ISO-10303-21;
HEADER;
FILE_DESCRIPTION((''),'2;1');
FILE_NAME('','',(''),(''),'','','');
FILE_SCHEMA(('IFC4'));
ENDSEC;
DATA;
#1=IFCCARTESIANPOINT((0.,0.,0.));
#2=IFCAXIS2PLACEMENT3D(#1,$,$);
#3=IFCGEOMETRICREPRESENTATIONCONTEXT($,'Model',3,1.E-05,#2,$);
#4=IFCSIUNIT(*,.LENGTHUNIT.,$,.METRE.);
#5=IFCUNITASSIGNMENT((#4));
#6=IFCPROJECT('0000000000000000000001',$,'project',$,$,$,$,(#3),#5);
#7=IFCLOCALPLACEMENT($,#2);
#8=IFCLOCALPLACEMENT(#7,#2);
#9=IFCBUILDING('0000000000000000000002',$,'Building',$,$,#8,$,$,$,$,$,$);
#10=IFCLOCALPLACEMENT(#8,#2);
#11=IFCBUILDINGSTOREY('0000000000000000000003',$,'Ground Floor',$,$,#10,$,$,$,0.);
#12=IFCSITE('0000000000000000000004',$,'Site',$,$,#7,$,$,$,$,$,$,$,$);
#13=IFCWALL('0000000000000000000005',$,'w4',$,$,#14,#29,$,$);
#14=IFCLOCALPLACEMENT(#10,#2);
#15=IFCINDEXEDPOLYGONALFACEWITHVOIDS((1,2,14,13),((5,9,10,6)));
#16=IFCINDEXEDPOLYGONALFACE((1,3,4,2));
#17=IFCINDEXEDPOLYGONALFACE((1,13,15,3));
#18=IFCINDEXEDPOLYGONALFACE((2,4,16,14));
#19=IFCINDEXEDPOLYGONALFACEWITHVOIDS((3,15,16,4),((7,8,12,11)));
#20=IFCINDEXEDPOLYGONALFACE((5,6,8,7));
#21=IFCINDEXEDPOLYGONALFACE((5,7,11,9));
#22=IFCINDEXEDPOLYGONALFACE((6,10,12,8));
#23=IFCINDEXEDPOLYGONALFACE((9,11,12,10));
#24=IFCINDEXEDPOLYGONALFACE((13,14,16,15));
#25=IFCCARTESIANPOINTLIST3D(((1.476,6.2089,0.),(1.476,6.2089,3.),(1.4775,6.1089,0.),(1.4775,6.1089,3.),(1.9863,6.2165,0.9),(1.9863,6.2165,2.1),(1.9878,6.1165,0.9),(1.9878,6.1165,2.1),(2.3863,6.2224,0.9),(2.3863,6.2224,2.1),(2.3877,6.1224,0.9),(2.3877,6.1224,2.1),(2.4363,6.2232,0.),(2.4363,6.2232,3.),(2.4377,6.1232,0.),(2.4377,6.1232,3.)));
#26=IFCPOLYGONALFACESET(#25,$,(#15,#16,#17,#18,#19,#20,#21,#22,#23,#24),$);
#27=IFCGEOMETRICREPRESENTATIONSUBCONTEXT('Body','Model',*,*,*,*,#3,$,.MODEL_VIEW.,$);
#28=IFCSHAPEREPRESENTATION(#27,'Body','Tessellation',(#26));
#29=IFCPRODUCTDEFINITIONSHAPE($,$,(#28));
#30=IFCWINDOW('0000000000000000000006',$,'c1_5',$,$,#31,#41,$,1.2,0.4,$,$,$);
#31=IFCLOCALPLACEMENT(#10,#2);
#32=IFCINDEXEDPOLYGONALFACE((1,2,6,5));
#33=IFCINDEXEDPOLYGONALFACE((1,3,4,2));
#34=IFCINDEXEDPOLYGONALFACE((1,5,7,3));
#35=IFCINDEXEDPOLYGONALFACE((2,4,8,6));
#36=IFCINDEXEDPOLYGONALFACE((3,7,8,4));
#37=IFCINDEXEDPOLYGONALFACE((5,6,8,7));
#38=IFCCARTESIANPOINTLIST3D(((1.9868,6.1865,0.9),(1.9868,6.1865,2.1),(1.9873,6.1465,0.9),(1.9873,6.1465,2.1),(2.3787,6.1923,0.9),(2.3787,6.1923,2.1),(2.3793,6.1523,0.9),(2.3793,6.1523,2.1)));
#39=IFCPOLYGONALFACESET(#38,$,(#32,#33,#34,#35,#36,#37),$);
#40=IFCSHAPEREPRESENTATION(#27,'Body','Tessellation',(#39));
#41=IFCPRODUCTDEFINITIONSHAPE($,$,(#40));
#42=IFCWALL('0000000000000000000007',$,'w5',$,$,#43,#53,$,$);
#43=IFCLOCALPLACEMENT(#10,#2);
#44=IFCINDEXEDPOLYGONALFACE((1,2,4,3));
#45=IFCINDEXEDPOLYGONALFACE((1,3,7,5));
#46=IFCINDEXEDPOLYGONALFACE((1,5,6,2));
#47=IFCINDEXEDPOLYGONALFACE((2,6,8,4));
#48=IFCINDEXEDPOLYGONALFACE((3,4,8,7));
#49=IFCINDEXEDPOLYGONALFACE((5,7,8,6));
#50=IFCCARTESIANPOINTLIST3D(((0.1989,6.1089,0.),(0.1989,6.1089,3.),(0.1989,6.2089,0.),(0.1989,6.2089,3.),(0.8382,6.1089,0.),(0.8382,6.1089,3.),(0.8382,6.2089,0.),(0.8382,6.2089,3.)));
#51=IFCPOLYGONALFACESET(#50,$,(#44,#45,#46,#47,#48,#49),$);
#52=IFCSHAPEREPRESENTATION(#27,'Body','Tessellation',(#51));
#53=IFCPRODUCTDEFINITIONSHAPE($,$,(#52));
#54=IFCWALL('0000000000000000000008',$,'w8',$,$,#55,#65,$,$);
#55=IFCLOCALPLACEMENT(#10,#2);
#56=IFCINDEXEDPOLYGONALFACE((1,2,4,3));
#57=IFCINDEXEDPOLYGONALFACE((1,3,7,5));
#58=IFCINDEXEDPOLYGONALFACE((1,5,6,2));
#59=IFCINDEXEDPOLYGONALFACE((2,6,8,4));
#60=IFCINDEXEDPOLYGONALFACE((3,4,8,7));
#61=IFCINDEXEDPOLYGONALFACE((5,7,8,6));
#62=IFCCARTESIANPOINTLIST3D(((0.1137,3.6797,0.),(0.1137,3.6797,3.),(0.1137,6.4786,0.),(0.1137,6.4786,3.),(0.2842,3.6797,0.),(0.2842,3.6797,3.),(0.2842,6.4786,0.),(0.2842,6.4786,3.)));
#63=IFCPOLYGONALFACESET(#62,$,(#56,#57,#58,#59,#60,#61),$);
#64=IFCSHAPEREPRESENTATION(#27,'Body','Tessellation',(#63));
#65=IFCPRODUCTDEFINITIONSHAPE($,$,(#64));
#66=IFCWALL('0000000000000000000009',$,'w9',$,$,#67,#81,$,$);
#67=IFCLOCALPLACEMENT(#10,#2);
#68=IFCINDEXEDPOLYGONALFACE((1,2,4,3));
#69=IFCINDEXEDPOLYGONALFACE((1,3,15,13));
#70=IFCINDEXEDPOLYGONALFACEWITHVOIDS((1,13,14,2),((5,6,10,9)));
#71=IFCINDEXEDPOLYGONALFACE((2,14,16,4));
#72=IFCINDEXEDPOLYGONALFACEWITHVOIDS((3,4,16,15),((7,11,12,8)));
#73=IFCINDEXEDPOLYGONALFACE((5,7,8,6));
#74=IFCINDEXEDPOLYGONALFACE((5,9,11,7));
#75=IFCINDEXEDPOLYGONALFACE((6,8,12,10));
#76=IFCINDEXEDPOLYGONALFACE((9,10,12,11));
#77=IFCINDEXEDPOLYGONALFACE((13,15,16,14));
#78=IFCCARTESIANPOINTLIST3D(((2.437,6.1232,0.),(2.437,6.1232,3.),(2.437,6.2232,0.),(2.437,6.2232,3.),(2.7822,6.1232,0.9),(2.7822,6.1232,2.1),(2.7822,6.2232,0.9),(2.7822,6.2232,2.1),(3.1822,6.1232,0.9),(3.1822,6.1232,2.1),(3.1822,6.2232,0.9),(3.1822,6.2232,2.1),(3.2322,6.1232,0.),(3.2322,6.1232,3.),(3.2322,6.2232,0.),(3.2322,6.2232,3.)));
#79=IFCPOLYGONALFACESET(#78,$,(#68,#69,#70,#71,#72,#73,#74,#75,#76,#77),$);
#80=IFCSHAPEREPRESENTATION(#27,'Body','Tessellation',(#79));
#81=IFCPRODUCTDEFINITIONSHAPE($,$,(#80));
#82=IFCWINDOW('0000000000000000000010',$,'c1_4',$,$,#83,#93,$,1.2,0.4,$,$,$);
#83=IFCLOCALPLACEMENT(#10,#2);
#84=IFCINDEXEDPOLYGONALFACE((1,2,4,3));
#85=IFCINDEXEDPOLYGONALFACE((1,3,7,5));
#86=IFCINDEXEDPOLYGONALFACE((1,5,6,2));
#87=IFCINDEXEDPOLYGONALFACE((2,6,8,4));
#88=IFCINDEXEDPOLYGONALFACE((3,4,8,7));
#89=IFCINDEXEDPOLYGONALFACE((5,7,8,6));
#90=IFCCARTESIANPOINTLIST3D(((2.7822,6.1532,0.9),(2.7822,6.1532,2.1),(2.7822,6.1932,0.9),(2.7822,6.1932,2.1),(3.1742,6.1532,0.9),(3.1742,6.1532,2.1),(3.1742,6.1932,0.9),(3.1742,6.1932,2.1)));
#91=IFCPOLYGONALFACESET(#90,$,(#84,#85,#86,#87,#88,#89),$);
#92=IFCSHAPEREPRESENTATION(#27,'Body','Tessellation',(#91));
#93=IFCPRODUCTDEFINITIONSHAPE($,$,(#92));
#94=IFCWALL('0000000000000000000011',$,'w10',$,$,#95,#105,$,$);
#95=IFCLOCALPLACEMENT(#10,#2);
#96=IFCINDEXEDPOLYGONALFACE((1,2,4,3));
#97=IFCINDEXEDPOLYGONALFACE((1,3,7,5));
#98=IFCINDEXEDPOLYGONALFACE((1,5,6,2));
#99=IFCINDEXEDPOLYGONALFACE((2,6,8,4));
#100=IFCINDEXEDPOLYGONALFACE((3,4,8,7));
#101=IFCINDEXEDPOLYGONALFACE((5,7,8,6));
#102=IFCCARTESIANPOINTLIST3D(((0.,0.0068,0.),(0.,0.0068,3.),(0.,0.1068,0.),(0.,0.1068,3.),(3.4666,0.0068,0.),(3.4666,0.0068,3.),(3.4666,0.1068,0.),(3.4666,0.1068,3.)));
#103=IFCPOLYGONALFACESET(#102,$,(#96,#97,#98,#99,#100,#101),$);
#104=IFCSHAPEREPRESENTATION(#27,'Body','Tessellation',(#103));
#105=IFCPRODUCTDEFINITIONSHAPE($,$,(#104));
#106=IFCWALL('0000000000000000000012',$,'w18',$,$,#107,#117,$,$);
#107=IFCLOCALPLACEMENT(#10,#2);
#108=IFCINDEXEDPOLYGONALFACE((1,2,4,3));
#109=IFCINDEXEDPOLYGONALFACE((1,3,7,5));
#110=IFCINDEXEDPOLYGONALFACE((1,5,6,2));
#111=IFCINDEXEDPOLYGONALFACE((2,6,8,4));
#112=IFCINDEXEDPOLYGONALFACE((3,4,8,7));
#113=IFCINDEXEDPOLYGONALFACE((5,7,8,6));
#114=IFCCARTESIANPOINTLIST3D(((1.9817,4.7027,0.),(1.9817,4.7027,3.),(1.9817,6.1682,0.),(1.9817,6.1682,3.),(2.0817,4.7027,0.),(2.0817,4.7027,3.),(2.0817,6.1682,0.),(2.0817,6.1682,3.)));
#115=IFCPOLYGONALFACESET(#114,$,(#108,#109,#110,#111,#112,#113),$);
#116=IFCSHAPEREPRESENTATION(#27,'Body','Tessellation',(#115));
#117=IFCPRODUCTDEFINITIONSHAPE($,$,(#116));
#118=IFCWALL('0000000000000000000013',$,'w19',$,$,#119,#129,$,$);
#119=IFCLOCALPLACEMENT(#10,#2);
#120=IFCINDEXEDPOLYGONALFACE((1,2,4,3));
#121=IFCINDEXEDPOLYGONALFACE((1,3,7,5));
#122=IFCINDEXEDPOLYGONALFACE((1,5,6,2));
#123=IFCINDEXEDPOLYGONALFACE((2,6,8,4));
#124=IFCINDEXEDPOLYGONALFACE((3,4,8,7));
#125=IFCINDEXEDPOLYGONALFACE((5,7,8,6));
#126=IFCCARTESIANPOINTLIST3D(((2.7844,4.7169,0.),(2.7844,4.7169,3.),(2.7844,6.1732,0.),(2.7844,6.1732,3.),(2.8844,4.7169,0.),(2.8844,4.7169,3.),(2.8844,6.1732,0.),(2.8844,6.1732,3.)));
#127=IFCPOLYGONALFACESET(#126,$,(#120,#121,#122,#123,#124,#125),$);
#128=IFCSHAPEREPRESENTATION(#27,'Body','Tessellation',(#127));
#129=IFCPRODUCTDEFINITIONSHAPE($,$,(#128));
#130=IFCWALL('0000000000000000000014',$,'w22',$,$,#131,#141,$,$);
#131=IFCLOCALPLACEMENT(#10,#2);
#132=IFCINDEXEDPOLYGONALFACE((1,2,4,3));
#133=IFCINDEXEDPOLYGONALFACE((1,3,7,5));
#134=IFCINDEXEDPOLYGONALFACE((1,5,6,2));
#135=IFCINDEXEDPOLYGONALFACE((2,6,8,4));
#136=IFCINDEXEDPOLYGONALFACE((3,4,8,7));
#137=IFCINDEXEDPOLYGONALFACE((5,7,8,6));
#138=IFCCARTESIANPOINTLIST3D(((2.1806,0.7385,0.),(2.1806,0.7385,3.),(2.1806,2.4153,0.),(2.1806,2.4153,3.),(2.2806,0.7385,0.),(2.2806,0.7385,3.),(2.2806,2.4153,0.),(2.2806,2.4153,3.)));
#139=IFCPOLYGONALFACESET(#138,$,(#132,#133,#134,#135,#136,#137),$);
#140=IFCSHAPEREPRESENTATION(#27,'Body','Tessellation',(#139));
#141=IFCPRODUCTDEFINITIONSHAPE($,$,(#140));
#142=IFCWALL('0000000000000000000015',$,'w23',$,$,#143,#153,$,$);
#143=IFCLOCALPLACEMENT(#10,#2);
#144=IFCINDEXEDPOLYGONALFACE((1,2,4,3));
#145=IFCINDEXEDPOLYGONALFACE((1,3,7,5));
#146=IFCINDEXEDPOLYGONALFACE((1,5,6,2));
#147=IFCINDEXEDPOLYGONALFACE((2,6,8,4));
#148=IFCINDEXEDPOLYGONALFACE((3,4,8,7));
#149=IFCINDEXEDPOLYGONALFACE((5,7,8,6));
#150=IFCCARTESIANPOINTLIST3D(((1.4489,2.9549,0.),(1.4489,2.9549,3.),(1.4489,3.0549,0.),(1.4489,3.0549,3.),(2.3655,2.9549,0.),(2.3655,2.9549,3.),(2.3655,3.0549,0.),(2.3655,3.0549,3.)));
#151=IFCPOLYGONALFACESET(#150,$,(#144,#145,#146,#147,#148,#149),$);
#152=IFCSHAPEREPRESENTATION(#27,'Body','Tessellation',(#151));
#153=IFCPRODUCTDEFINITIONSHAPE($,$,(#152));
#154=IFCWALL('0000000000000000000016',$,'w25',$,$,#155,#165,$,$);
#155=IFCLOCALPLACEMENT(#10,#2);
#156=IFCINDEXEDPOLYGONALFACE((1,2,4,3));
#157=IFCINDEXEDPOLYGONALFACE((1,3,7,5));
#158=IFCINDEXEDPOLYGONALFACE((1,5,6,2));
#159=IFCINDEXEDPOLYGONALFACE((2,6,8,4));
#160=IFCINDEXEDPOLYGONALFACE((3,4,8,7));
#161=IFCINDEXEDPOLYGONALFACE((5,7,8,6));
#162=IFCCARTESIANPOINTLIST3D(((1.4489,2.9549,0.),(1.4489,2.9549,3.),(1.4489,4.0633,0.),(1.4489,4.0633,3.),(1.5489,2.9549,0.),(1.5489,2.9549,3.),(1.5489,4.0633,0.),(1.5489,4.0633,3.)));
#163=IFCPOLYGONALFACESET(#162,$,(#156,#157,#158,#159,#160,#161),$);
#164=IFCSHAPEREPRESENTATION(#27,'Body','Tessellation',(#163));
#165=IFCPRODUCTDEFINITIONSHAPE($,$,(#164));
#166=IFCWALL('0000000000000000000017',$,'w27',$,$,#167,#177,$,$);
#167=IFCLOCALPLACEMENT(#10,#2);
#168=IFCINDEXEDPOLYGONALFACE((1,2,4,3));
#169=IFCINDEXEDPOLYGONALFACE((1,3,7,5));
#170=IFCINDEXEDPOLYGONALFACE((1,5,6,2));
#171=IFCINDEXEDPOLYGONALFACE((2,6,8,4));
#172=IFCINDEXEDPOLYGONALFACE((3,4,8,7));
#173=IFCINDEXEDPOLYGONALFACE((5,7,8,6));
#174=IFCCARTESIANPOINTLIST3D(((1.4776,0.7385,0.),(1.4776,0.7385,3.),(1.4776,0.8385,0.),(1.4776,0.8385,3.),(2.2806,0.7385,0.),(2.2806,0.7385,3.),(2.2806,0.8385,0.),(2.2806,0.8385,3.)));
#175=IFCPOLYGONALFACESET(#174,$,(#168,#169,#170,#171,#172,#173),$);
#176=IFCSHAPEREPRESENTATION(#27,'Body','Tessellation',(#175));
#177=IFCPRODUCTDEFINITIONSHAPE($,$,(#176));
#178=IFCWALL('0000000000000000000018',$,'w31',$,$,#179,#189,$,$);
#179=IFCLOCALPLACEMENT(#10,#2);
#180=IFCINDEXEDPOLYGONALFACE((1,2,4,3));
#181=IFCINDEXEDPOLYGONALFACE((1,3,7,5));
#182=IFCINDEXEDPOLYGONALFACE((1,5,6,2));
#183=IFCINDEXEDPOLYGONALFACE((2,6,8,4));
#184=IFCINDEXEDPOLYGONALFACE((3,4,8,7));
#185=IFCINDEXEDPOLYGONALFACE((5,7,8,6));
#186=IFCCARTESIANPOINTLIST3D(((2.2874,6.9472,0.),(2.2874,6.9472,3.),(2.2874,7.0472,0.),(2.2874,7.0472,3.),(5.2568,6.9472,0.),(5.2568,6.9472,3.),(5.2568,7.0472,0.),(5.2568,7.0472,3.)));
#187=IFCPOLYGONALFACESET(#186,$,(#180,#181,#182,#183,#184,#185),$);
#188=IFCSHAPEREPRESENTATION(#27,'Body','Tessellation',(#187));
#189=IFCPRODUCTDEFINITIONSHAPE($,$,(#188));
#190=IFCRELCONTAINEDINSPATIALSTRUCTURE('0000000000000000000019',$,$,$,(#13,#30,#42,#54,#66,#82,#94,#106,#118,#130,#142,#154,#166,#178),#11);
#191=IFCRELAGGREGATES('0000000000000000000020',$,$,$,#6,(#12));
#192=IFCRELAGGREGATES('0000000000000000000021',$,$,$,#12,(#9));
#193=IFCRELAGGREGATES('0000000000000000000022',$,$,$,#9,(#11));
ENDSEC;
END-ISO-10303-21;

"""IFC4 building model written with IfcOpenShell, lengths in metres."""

from ifc_helpers import new_model, si_unit, frame, origin, place, context, subcontext, project, spatial, polyline, outline, extrude, element, fill, save


model = new_model("IFC4")

# Units and contexts
model_context = context("Model", 3, precision=1e-05, world=origin())
body_context = subcontext(model_context, "Body", "Model", "MODEL_VIEW")
ifc_project = project(units=[si_unit("LENGTHUNIT", "METRE")], contexts=[model_context])

# Site, building, storey
site_placement = place(None, origin())
site = spatial("IfcSite", under=ifc_project, at=site_placement, Name="Site")
building_placement = place(site_placement, origin())
building = spatial("IfcBuilding", under=site, at=building_placement, Name="Building")
storey_placement = place(building_placement, origin())
storey = spatial("IfcBuildingStorey", under=building, at=storey_placement, Name="Ground Floor", Elevation=0.0)

# Wall, opening, window
wall_1_placement = place(storey_placement, frame((1.4768, 6.1589, 0.0), x_axis=(0.99989, 0.014814, 0.0)))
wall_1 = element("IfcWall", 1, at=wall_1_placement, inside=storey, Name="w4", context=body_context, shape_type="SweptSolid", body=[
    extrude(outline(polyline([(0.0, -0.05), (0.9604, -0.05), (0.9604, 0.05), (0.0, 0.05), (0.0, -0.05)])), origin(), (0.0, 0.0, 1.0), 3.0),
])
opening_1_placement = place(wall_1_placement, frame((0.5104, 0.0, 0.0)))
opening_1 = element("IfcOpeningElement", 2, at=opening_1_placement, cuts=wall_1, context=body_context, shape_type="SweptSolid", body=[
    extrude(outline(polyline([(0.0, -0.0525), (0.4, -0.0525), (0.4, 0.0525), (0.0, 0.0525), (0.0, -0.0525)])), frame((0.0, 0.0, 0.9)), (0.0, 0.0, 1.0), 1.2),
])
window_1_placement = place(wall_1_placement, frame((0.5104, 0.0, 0.0)))
window_1 = element("IfcWindow", 3, at=window_1_placement, inside=storey, Name="c1_5", OverallHeight=1.2, OverallWidth=0.4, context=body_context, shape_type="SweptSolid", body=[
    extrude(outline(polyline([(0.0, -0.02), (0.392, -0.02), (0.392, 0.02), (0.0, 0.02), (0.0, -0.02)])), frame((0.0, 0.0, 0.9)), (0.0, 0.0, 1.0), 1.2),
])
fill(opening_1, window_1)

# Walls
wall_2_placement = place(storey_placement, frame((0.1989, 6.1589, 0.0), x_axis=(1.0, 0.0, 0.0)))
element("IfcWall", 4, at=wall_2_placement, inside=storey, Name="w5", context=body_context, shape_type="SweptSolid", body=[
    extrude(outline(polyline([(0.0, -0.05), (0.6393, -0.05), (0.6393, 0.05), (0.0, 0.05), (0.0, -0.05)])), origin(), (0.0, 0.0, 1.0), 3.0),
])
wall_3_placement = place(storey_placement, frame((0.1989, 3.6797, 0.0), x_axis=(0.0, 1.0, 0.0)))
element("IfcWall", 5, at=wall_3_placement, inside=storey, Name="w8", context=body_context, shape_type="SweptSolid", body=[
    extrude(outline(polyline([(0.0, -0.0852), (2.7989, -0.0852), (2.7989, 0.0852), (0.0, 0.0852), (0.0, -0.0852)])), origin(), (0.0, 0.0, 1.0), 3.0),
])

# Wall, opening, window
wall_4_placement = place(storey_placement, frame((2.437, 6.1732, 0.0), x_axis=(1.0, -0.000009, 0.0)))
wall_4 = element("IfcWall", 6, at=wall_4_placement, inside=storey, Name="w9", context=body_context, shape_type="SweptSolid", body=[
    extrude(outline(polyline([(0.0, -0.05), (0.7952, -0.05), (0.7952, 0.05), (0.0, 0.05), (0.0, -0.05)])), origin(), (0.0, 0.0, 1.0), 3.0),
])
opening_2_placement = place(wall_4_placement, frame((0.3452, 0.0, 0.0)))
opening_2 = element("IfcOpeningElement", 7, at=opening_2_placement, cuts=wall_4, context=body_context, shape_type="SweptSolid", body=[
    extrude(outline(polyline([(0.0, -0.0525), (0.4, -0.0525), (0.4, 0.0525), (0.0, 0.0525), (0.0, -0.0525)])), frame((0.0, 0.0, 0.9)), (0.0, 0.0, 1.0), 1.2),
])
window_2_placement = place(wall_4_placement, frame((0.3452, 0.0, 0.0)))
window_2 = element("IfcWindow", 8, at=window_2_placement, inside=storey, Name="c1_4", OverallHeight=1.2, OverallWidth=0.4, context=body_context, shape_type="SweptSolid", body=[
    extrude(outline(polyline([(0.0, -0.02), (0.392, -0.02), (0.392, 0.02), (0.0, 0.02), (0.0, -0.02)])), frame((0.0, 0.0, 0.9)), (0.0, 0.0, 1.0), 1.2),
])
fill(opening_2, window_2)

# Walls
wall_5_placement = place(storey_placement, frame((0.0, 0.0568, 0.0), x_axis=(1.0, 0.0, 0.0)))
element("IfcWall", 9, at=wall_5_placement, inside=storey, Name="w10", context=body_context, shape_type="SweptSolid", body=[
    extrude(outline(polyline([(0.0, -0.05), (3.4666, -0.05), (3.4666, 0.05), (0.0, 0.05), (0.0, -0.05)])), origin(), (0.0, 0.0, 1.0), 3.0),
])
wall_6_placement = place(storey_placement, frame((2.0317, 4.7027, 0.0), x_axis=(0.0, 1.0, 0.0)))
element("IfcWall", 10, at=wall_6_placement, inside=storey, Name="w18", context=body_context, shape_type="SweptSolid", body=[
    extrude(outline(polyline([(0.0, -0.05), (1.4655, -0.05), (1.4655, 0.05), (0.0, 0.05), (0.0, -0.05)])), origin(), (0.0, 0.0, 1.0), 3.0),
])
wall_7_placement = place(storey_placement, frame((2.8344, 4.7169, 0.0), x_axis=(0.0, 1.0, 0.0)))
element("IfcWall", 11, at=wall_7_placement, inside=storey, Name="w19", context=body_context, shape_type="SweptSolid", body=[
    extrude(outline(polyline([(0.0, -0.05), (1.4563, -0.05), (1.4563, 0.05), (0.0, 0.05), (0.0, -0.05)])), origin(), (0.0, 0.0, 1.0), 3.0),
])
wall_8_placement = place(storey_placement, frame((2.2306, 0.7885, 0.0), x_axis=(0.0, 1.0, 0.0)))
element("IfcWall", 12, at=wall_8_placement, inside=storey, Name="w22", context=body_context, shape_type="SweptSolid", body=[
    extrude(outline(polyline([(-0.05, -0.05), (1.6268, -0.05), (1.6268, 0.05), (-0.05, 0.05), (-0.05, -0.05)])), origin(), (0.0, 0.0, 1.0), 3.0),
])
wall_9_placement = place(storey_placement, frame((1.4989, 3.0049, 0.0), x_axis=(1.0, 0.0, 0.0)))
element("IfcWall", 13, at=wall_9_placement, inside=storey, Name="w23", context=body_context, shape_type="SweptSolid", body=[
    extrude(outline(polyline([(-0.05, -0.05), (0.8667, -0.05), (0.8667, 0.05), (-0.05, 0.05), (-0.05, -0.05)])), origin(), (0.0, 0.0, 1.0), 3.0),
])
wall_10_placement = place(storey_placement, frame((1.4989, 3.0049, 0.0), x_axis=(0.0, 1.0, 0.0)))
element("IfcWall", 14, at=wall_10_placement, inside=storey, Name="w25", context=body_context, shape_type="SweptSolid", body=[
    extrude(outline(polyline([(-0.05, -0.05), (1.0585, -0.05), (1.0585, 0.05), (-0.05, 0.05), (-0.05, -0.05)])), origin(), (0.0, 0.0, 1.0), 3.0),
])
wall_11_placement = place(storey_placement, frame((1.4776, 0.7885, 0.0), x_axis=(1.0, 0.0, 0.0)))
element("IfcWall", 15, at=wall_11_placement, inside=storey, Name="w27", context=body_context, shape_type="SweptSolid", body=[
    extrude(outline(polyline([(0.0, -0.05), (0.803, -0.05), (0.803, 0.05), (0.0, 0.05), (0.0, -0.05)])), origin(), (0.0, 0.0, 1.0), 3.0),
])
wall_12_placement = place(storey_placement, frame((2.2874, 6.9972, 0.0), x_axis=(1.0, 0.0, 0.0)))
element("IfcWall", 16, at=wall_12_placement, inside=storey, Name="w31", context=body_context, shape_type="SweptSolid", body=[
    extrude(outline(polyline([(0.0, -0.05), (2.9694, -0.05), (2.9694, 0.05), (0.0, 0.05), (0.0, -0.05)])), origin(), (0.0, 0.0, 1.0), 3.0),
])

save(model, "model.ifc")
